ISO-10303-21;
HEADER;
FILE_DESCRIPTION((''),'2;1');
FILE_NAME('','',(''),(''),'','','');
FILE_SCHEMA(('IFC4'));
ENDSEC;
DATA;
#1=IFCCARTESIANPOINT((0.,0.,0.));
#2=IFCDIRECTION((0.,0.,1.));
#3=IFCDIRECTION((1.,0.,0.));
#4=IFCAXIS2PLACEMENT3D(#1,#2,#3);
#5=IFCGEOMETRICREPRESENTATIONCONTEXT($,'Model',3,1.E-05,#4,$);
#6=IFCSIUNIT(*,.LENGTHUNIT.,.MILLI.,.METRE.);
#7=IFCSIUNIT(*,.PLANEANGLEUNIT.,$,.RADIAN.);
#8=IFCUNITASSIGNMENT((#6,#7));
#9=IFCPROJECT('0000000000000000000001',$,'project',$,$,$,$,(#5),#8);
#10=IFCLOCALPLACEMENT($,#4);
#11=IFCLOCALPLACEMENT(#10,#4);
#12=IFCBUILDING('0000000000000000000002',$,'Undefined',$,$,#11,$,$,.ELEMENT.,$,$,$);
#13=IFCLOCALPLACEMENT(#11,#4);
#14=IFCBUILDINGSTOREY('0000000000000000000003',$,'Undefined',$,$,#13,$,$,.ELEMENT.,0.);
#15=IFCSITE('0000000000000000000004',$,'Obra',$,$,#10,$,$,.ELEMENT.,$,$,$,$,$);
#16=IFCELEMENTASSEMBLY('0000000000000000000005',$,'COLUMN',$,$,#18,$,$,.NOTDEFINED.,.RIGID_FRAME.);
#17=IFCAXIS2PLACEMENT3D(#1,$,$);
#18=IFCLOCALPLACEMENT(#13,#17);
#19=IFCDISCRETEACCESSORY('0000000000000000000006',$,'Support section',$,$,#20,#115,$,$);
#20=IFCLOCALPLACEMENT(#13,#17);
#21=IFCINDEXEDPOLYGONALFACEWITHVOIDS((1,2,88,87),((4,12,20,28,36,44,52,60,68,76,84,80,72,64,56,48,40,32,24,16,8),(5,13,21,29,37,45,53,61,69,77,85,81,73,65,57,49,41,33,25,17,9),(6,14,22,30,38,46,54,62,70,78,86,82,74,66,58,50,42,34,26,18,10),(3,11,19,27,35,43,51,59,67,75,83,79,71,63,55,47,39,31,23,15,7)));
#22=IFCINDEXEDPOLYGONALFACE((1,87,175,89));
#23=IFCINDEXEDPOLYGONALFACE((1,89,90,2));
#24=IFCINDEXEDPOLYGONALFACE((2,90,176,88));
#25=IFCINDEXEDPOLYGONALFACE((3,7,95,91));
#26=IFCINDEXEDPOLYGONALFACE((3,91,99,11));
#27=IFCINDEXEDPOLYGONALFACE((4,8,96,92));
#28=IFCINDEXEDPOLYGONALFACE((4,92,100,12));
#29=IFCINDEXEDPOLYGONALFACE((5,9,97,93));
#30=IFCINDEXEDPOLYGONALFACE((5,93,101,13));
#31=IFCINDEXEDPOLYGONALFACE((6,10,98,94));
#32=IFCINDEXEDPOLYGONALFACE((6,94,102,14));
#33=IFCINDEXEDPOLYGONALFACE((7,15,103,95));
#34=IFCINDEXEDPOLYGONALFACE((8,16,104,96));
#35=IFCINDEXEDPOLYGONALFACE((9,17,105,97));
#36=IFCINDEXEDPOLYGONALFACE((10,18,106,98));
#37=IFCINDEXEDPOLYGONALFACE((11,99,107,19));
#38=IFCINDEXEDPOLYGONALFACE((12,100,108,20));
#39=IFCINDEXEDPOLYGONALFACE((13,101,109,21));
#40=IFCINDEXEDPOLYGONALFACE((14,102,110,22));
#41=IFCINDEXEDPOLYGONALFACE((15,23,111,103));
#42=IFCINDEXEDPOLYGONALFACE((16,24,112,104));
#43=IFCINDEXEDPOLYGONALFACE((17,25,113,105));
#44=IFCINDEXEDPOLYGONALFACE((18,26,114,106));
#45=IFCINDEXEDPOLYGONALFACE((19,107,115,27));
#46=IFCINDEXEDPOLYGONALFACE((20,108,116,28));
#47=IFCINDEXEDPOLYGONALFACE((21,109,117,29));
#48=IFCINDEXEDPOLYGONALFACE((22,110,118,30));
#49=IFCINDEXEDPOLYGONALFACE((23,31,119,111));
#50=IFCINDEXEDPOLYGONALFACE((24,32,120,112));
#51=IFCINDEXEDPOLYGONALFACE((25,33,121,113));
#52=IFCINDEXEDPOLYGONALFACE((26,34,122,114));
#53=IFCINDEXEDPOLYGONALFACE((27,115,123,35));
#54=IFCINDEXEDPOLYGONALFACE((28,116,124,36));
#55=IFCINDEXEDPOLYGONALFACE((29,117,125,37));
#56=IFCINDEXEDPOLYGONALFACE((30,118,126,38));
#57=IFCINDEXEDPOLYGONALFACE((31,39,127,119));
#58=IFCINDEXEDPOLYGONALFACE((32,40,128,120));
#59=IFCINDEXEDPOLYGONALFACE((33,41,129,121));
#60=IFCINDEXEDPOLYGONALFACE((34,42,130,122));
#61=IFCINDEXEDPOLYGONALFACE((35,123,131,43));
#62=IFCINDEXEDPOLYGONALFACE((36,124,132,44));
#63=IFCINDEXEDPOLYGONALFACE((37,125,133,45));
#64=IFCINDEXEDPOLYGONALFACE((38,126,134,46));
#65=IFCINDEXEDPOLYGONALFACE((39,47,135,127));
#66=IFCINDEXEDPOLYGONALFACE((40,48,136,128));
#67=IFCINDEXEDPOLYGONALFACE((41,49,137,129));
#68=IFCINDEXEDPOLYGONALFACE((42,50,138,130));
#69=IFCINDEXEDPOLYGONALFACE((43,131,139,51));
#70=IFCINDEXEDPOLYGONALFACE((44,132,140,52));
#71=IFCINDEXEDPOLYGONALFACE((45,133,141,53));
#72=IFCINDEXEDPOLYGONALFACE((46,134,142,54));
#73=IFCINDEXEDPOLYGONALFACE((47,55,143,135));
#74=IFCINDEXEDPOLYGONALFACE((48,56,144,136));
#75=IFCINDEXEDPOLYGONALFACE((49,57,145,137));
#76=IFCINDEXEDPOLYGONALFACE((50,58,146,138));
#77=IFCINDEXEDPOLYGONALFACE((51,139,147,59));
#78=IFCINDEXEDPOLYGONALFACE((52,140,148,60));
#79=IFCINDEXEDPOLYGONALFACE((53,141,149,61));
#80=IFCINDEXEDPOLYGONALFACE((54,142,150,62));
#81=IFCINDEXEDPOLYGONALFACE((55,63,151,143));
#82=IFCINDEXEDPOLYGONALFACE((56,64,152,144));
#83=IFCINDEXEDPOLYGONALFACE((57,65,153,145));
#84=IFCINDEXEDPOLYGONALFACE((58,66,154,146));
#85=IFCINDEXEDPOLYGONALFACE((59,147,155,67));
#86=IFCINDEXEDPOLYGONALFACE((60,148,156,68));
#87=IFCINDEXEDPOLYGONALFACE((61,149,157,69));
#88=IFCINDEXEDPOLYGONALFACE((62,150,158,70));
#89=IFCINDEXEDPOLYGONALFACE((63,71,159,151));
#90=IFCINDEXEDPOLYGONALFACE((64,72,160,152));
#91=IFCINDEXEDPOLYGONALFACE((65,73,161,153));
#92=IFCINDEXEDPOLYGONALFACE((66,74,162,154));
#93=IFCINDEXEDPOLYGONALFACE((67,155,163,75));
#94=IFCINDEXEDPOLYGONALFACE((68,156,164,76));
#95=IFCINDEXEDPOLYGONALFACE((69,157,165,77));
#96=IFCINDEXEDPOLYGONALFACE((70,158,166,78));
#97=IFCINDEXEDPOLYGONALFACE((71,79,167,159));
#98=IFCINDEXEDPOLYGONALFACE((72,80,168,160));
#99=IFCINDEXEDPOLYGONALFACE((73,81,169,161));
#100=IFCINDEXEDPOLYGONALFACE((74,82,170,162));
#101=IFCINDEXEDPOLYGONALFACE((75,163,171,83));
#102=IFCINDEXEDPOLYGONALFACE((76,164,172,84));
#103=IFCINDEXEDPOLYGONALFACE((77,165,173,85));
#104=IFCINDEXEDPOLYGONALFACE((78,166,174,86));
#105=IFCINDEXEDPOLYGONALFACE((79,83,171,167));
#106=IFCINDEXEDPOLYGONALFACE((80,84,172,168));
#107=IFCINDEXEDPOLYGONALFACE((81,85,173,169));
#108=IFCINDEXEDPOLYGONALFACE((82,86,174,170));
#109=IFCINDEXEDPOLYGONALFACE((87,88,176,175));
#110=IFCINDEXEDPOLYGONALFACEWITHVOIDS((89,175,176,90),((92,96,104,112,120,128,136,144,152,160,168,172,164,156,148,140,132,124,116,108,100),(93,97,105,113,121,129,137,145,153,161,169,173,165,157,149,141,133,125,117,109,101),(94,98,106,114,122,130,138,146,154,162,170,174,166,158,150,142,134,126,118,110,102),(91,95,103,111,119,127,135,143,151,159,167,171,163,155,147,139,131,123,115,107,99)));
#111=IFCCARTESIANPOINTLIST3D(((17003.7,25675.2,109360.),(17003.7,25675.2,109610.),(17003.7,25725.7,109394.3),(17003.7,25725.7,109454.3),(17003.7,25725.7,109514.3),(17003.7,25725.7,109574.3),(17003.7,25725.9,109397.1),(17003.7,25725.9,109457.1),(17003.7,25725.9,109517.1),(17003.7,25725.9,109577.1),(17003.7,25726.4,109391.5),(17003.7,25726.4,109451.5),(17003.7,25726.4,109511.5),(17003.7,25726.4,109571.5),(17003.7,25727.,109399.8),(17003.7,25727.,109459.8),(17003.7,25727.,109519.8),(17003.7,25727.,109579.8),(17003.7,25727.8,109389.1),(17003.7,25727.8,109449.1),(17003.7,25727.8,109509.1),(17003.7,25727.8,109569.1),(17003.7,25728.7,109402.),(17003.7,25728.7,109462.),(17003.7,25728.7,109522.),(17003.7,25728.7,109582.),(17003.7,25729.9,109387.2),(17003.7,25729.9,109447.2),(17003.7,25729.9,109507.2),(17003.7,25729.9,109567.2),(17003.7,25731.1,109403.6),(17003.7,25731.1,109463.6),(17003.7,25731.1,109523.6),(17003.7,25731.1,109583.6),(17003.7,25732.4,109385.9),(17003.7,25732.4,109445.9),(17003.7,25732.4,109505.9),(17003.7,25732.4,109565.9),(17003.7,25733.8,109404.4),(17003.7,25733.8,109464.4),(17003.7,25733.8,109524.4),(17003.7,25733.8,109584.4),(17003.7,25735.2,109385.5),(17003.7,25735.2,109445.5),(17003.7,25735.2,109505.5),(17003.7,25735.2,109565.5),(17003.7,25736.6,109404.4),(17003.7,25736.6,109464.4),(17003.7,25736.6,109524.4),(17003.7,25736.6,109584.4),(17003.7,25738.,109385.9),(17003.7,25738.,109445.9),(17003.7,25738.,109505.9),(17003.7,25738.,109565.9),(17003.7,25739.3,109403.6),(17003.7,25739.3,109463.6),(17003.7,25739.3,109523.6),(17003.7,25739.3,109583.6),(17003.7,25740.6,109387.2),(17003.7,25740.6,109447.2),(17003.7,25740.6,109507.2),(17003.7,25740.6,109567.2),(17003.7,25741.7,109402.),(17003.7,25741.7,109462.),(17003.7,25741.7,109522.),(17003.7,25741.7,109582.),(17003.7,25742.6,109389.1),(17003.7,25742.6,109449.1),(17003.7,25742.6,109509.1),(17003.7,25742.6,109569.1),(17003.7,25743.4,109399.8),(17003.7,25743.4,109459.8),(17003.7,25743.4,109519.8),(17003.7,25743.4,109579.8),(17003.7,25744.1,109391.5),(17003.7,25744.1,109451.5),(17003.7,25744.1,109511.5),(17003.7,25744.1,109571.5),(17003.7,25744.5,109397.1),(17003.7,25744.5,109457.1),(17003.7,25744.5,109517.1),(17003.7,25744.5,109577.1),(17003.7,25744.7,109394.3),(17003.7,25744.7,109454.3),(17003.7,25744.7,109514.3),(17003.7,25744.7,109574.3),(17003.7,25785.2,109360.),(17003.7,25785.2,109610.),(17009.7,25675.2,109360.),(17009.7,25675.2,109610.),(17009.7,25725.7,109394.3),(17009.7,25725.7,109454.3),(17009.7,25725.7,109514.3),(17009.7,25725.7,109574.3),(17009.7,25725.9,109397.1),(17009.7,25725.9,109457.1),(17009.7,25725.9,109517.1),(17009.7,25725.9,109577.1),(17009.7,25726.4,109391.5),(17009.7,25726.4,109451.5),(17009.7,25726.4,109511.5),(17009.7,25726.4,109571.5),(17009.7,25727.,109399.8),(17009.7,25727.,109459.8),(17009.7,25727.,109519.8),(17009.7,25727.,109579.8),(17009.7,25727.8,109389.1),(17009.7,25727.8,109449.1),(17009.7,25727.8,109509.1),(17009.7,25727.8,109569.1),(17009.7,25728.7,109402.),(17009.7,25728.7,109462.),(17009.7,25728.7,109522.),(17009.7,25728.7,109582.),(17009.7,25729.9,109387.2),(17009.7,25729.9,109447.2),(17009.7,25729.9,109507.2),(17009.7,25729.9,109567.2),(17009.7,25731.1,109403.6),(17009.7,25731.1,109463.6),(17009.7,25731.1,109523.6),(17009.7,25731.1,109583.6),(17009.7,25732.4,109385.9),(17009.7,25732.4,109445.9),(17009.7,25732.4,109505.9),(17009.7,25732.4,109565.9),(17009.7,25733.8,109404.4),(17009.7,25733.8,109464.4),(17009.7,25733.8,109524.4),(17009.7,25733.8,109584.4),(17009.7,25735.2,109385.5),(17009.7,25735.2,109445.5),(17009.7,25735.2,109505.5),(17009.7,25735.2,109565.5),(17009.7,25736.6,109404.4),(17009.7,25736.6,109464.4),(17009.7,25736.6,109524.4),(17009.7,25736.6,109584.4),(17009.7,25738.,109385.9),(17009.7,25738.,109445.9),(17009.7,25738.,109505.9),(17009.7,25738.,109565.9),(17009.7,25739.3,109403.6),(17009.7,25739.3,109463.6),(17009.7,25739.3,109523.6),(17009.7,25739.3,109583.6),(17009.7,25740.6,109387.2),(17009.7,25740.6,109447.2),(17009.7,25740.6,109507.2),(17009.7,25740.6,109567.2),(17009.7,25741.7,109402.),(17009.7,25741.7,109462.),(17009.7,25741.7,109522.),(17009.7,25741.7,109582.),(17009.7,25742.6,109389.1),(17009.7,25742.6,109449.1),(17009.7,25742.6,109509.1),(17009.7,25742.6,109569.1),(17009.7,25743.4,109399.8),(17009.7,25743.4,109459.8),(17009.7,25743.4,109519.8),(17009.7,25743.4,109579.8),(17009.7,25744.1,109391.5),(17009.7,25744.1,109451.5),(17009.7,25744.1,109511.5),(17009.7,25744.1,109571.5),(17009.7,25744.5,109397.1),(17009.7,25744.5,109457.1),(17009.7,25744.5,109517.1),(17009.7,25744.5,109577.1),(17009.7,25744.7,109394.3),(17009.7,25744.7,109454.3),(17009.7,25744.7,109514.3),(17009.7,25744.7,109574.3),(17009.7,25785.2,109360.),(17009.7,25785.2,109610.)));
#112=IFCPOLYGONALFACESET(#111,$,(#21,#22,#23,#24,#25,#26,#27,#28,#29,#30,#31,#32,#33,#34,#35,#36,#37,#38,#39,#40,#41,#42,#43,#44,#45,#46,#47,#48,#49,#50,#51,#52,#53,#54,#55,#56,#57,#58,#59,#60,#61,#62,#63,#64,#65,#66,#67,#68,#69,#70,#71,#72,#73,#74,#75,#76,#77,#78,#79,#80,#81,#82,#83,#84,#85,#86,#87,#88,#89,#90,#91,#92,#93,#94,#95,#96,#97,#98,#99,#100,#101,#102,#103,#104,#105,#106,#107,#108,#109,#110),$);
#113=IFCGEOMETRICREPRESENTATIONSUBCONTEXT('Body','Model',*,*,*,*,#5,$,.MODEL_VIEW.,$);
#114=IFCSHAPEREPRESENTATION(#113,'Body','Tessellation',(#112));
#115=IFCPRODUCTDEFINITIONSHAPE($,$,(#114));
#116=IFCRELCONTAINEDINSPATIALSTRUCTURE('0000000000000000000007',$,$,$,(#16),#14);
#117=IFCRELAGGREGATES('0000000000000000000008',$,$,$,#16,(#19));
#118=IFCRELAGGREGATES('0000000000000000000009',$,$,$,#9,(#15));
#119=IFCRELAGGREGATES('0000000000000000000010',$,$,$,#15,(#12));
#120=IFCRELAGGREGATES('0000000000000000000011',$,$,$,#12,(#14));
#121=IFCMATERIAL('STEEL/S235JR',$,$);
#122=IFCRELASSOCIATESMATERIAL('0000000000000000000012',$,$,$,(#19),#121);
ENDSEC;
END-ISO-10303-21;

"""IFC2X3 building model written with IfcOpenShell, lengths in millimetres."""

from ifc_helpers import new_model, si_unit, frame, origin_with_axes, origin_2d_with_axis, place, context, subcontext, project, spatial, rectangle, circle, extrude, source, transform, mapped, material, element, aggregate, save


model = new_model("IFC2X3")

# Units and contexts
model_context = context("Model", 3, precision=1e-05, world=origin_with_axes())
body_context = subcontext(model_context, "Body", "Model", "MODEL_VIEW")
ifc_project = project(units=[si_unit("LENGTHUNIT", "METRE", prefix="MILLI"), si_unit("PLANEANGLEUNIT", "RADIAN")], contexts=[model_context])

# Site, building, storey
site_placement = place(None, origin_with_axes())
site = spatial("IfcSite", under=ifc_project, at=site_placement, Name="Obra", CompositionType="ELEMENT")
building_placement = place(site_placement, origin_with_axes())
building = spatial("IfcBuilding", under=site, at=building_placement, Name="Undefined", CompositionType="ELEMENT")
storey_placement = place(building_placement, origin_with_axes())
storey = spatial("IfcBuildingStorey", under=building, at=storey_placement, Name="Undefined", CompositionType="ELEMENT", Elevation=0.0)

# Element assembly, discrete accessory, opening
ifc_material_1 = material(Name="STEEL/S235JR")
shared_shape_1 = source(origin_with_axes(), body_context, "Body", "SweptSolid", [
    extrude(circle(Radius=9.5, at=origin_2d_with_axis()), frame((0.0, -9.8, 0.0), z_axis=(0.0, 1.0, 0.0), x_axis=(1.0, 0.0, 0.0)), (0.0, 0.0, 1.0), 6.2),
])
assembly_1_placement = place(storey_placement, origin_with_axes())
assembly_1 = element("IfcElementAssembly", 1, at=assembly_1_placement, inside=storey, Name="COLUMN", AssemblyPlace="NOTDEFINED", PredefinedType="RIGID_FRAME")
discrete_accessory_1_placement = place(assembly_1_placement, frame((17006.7, 25730.2, 109360.0), z_axis=(0.0, 0.0, 1.0), x_axis=(0.0, -1.0, 0.0)))
discrete_accessory_1 = element("IfcDiscreteAccessory", 2, at=discrete_accessory_1_placement, material=ifc_material_1, Name="Support section", context=body_context, shape_type="SweptSolid", body=[
    extrude(rectangle(XDim=6.0, YDim=110.0, at=origin_2d_with_axis()), frame((0.0, 0.0, 250.0), z_axis=(0.0, 0.0, -1.0), x_axis=(0.0, 1.0, 0.0)), (0.0, 0.0, 1.0), 250.0),
])
opening_1_placement = place(assembly_1_placement, frame((17000.0, 25685.2, 109650.0), z_axis=(0.0, 1.0, 0.0), x_axis=(0.0, 0.0, -1.0)))
element("IfcOpeningElement", 3, at=opening_1_placement, cuts=discrete_accessory_1, ObjectType="Opening", context=body_context, shape_type="MappedRepresentation", body=[
    mapped(shared_shape_1, transform((75.0, 0.0, 50.0))),
    mapped(shared_shape_1, transform((135.0, 0.0, 50.0))),
    mapped(shared_shape_1, transform((195.0, 0.0, 50.0))),
    mapped(shared_shape_1, transform((255.0, 0.0, 50.0))),
])
aggregate(assembly_1, [discrete_accessory_1])

save(model, "model.ifc")
